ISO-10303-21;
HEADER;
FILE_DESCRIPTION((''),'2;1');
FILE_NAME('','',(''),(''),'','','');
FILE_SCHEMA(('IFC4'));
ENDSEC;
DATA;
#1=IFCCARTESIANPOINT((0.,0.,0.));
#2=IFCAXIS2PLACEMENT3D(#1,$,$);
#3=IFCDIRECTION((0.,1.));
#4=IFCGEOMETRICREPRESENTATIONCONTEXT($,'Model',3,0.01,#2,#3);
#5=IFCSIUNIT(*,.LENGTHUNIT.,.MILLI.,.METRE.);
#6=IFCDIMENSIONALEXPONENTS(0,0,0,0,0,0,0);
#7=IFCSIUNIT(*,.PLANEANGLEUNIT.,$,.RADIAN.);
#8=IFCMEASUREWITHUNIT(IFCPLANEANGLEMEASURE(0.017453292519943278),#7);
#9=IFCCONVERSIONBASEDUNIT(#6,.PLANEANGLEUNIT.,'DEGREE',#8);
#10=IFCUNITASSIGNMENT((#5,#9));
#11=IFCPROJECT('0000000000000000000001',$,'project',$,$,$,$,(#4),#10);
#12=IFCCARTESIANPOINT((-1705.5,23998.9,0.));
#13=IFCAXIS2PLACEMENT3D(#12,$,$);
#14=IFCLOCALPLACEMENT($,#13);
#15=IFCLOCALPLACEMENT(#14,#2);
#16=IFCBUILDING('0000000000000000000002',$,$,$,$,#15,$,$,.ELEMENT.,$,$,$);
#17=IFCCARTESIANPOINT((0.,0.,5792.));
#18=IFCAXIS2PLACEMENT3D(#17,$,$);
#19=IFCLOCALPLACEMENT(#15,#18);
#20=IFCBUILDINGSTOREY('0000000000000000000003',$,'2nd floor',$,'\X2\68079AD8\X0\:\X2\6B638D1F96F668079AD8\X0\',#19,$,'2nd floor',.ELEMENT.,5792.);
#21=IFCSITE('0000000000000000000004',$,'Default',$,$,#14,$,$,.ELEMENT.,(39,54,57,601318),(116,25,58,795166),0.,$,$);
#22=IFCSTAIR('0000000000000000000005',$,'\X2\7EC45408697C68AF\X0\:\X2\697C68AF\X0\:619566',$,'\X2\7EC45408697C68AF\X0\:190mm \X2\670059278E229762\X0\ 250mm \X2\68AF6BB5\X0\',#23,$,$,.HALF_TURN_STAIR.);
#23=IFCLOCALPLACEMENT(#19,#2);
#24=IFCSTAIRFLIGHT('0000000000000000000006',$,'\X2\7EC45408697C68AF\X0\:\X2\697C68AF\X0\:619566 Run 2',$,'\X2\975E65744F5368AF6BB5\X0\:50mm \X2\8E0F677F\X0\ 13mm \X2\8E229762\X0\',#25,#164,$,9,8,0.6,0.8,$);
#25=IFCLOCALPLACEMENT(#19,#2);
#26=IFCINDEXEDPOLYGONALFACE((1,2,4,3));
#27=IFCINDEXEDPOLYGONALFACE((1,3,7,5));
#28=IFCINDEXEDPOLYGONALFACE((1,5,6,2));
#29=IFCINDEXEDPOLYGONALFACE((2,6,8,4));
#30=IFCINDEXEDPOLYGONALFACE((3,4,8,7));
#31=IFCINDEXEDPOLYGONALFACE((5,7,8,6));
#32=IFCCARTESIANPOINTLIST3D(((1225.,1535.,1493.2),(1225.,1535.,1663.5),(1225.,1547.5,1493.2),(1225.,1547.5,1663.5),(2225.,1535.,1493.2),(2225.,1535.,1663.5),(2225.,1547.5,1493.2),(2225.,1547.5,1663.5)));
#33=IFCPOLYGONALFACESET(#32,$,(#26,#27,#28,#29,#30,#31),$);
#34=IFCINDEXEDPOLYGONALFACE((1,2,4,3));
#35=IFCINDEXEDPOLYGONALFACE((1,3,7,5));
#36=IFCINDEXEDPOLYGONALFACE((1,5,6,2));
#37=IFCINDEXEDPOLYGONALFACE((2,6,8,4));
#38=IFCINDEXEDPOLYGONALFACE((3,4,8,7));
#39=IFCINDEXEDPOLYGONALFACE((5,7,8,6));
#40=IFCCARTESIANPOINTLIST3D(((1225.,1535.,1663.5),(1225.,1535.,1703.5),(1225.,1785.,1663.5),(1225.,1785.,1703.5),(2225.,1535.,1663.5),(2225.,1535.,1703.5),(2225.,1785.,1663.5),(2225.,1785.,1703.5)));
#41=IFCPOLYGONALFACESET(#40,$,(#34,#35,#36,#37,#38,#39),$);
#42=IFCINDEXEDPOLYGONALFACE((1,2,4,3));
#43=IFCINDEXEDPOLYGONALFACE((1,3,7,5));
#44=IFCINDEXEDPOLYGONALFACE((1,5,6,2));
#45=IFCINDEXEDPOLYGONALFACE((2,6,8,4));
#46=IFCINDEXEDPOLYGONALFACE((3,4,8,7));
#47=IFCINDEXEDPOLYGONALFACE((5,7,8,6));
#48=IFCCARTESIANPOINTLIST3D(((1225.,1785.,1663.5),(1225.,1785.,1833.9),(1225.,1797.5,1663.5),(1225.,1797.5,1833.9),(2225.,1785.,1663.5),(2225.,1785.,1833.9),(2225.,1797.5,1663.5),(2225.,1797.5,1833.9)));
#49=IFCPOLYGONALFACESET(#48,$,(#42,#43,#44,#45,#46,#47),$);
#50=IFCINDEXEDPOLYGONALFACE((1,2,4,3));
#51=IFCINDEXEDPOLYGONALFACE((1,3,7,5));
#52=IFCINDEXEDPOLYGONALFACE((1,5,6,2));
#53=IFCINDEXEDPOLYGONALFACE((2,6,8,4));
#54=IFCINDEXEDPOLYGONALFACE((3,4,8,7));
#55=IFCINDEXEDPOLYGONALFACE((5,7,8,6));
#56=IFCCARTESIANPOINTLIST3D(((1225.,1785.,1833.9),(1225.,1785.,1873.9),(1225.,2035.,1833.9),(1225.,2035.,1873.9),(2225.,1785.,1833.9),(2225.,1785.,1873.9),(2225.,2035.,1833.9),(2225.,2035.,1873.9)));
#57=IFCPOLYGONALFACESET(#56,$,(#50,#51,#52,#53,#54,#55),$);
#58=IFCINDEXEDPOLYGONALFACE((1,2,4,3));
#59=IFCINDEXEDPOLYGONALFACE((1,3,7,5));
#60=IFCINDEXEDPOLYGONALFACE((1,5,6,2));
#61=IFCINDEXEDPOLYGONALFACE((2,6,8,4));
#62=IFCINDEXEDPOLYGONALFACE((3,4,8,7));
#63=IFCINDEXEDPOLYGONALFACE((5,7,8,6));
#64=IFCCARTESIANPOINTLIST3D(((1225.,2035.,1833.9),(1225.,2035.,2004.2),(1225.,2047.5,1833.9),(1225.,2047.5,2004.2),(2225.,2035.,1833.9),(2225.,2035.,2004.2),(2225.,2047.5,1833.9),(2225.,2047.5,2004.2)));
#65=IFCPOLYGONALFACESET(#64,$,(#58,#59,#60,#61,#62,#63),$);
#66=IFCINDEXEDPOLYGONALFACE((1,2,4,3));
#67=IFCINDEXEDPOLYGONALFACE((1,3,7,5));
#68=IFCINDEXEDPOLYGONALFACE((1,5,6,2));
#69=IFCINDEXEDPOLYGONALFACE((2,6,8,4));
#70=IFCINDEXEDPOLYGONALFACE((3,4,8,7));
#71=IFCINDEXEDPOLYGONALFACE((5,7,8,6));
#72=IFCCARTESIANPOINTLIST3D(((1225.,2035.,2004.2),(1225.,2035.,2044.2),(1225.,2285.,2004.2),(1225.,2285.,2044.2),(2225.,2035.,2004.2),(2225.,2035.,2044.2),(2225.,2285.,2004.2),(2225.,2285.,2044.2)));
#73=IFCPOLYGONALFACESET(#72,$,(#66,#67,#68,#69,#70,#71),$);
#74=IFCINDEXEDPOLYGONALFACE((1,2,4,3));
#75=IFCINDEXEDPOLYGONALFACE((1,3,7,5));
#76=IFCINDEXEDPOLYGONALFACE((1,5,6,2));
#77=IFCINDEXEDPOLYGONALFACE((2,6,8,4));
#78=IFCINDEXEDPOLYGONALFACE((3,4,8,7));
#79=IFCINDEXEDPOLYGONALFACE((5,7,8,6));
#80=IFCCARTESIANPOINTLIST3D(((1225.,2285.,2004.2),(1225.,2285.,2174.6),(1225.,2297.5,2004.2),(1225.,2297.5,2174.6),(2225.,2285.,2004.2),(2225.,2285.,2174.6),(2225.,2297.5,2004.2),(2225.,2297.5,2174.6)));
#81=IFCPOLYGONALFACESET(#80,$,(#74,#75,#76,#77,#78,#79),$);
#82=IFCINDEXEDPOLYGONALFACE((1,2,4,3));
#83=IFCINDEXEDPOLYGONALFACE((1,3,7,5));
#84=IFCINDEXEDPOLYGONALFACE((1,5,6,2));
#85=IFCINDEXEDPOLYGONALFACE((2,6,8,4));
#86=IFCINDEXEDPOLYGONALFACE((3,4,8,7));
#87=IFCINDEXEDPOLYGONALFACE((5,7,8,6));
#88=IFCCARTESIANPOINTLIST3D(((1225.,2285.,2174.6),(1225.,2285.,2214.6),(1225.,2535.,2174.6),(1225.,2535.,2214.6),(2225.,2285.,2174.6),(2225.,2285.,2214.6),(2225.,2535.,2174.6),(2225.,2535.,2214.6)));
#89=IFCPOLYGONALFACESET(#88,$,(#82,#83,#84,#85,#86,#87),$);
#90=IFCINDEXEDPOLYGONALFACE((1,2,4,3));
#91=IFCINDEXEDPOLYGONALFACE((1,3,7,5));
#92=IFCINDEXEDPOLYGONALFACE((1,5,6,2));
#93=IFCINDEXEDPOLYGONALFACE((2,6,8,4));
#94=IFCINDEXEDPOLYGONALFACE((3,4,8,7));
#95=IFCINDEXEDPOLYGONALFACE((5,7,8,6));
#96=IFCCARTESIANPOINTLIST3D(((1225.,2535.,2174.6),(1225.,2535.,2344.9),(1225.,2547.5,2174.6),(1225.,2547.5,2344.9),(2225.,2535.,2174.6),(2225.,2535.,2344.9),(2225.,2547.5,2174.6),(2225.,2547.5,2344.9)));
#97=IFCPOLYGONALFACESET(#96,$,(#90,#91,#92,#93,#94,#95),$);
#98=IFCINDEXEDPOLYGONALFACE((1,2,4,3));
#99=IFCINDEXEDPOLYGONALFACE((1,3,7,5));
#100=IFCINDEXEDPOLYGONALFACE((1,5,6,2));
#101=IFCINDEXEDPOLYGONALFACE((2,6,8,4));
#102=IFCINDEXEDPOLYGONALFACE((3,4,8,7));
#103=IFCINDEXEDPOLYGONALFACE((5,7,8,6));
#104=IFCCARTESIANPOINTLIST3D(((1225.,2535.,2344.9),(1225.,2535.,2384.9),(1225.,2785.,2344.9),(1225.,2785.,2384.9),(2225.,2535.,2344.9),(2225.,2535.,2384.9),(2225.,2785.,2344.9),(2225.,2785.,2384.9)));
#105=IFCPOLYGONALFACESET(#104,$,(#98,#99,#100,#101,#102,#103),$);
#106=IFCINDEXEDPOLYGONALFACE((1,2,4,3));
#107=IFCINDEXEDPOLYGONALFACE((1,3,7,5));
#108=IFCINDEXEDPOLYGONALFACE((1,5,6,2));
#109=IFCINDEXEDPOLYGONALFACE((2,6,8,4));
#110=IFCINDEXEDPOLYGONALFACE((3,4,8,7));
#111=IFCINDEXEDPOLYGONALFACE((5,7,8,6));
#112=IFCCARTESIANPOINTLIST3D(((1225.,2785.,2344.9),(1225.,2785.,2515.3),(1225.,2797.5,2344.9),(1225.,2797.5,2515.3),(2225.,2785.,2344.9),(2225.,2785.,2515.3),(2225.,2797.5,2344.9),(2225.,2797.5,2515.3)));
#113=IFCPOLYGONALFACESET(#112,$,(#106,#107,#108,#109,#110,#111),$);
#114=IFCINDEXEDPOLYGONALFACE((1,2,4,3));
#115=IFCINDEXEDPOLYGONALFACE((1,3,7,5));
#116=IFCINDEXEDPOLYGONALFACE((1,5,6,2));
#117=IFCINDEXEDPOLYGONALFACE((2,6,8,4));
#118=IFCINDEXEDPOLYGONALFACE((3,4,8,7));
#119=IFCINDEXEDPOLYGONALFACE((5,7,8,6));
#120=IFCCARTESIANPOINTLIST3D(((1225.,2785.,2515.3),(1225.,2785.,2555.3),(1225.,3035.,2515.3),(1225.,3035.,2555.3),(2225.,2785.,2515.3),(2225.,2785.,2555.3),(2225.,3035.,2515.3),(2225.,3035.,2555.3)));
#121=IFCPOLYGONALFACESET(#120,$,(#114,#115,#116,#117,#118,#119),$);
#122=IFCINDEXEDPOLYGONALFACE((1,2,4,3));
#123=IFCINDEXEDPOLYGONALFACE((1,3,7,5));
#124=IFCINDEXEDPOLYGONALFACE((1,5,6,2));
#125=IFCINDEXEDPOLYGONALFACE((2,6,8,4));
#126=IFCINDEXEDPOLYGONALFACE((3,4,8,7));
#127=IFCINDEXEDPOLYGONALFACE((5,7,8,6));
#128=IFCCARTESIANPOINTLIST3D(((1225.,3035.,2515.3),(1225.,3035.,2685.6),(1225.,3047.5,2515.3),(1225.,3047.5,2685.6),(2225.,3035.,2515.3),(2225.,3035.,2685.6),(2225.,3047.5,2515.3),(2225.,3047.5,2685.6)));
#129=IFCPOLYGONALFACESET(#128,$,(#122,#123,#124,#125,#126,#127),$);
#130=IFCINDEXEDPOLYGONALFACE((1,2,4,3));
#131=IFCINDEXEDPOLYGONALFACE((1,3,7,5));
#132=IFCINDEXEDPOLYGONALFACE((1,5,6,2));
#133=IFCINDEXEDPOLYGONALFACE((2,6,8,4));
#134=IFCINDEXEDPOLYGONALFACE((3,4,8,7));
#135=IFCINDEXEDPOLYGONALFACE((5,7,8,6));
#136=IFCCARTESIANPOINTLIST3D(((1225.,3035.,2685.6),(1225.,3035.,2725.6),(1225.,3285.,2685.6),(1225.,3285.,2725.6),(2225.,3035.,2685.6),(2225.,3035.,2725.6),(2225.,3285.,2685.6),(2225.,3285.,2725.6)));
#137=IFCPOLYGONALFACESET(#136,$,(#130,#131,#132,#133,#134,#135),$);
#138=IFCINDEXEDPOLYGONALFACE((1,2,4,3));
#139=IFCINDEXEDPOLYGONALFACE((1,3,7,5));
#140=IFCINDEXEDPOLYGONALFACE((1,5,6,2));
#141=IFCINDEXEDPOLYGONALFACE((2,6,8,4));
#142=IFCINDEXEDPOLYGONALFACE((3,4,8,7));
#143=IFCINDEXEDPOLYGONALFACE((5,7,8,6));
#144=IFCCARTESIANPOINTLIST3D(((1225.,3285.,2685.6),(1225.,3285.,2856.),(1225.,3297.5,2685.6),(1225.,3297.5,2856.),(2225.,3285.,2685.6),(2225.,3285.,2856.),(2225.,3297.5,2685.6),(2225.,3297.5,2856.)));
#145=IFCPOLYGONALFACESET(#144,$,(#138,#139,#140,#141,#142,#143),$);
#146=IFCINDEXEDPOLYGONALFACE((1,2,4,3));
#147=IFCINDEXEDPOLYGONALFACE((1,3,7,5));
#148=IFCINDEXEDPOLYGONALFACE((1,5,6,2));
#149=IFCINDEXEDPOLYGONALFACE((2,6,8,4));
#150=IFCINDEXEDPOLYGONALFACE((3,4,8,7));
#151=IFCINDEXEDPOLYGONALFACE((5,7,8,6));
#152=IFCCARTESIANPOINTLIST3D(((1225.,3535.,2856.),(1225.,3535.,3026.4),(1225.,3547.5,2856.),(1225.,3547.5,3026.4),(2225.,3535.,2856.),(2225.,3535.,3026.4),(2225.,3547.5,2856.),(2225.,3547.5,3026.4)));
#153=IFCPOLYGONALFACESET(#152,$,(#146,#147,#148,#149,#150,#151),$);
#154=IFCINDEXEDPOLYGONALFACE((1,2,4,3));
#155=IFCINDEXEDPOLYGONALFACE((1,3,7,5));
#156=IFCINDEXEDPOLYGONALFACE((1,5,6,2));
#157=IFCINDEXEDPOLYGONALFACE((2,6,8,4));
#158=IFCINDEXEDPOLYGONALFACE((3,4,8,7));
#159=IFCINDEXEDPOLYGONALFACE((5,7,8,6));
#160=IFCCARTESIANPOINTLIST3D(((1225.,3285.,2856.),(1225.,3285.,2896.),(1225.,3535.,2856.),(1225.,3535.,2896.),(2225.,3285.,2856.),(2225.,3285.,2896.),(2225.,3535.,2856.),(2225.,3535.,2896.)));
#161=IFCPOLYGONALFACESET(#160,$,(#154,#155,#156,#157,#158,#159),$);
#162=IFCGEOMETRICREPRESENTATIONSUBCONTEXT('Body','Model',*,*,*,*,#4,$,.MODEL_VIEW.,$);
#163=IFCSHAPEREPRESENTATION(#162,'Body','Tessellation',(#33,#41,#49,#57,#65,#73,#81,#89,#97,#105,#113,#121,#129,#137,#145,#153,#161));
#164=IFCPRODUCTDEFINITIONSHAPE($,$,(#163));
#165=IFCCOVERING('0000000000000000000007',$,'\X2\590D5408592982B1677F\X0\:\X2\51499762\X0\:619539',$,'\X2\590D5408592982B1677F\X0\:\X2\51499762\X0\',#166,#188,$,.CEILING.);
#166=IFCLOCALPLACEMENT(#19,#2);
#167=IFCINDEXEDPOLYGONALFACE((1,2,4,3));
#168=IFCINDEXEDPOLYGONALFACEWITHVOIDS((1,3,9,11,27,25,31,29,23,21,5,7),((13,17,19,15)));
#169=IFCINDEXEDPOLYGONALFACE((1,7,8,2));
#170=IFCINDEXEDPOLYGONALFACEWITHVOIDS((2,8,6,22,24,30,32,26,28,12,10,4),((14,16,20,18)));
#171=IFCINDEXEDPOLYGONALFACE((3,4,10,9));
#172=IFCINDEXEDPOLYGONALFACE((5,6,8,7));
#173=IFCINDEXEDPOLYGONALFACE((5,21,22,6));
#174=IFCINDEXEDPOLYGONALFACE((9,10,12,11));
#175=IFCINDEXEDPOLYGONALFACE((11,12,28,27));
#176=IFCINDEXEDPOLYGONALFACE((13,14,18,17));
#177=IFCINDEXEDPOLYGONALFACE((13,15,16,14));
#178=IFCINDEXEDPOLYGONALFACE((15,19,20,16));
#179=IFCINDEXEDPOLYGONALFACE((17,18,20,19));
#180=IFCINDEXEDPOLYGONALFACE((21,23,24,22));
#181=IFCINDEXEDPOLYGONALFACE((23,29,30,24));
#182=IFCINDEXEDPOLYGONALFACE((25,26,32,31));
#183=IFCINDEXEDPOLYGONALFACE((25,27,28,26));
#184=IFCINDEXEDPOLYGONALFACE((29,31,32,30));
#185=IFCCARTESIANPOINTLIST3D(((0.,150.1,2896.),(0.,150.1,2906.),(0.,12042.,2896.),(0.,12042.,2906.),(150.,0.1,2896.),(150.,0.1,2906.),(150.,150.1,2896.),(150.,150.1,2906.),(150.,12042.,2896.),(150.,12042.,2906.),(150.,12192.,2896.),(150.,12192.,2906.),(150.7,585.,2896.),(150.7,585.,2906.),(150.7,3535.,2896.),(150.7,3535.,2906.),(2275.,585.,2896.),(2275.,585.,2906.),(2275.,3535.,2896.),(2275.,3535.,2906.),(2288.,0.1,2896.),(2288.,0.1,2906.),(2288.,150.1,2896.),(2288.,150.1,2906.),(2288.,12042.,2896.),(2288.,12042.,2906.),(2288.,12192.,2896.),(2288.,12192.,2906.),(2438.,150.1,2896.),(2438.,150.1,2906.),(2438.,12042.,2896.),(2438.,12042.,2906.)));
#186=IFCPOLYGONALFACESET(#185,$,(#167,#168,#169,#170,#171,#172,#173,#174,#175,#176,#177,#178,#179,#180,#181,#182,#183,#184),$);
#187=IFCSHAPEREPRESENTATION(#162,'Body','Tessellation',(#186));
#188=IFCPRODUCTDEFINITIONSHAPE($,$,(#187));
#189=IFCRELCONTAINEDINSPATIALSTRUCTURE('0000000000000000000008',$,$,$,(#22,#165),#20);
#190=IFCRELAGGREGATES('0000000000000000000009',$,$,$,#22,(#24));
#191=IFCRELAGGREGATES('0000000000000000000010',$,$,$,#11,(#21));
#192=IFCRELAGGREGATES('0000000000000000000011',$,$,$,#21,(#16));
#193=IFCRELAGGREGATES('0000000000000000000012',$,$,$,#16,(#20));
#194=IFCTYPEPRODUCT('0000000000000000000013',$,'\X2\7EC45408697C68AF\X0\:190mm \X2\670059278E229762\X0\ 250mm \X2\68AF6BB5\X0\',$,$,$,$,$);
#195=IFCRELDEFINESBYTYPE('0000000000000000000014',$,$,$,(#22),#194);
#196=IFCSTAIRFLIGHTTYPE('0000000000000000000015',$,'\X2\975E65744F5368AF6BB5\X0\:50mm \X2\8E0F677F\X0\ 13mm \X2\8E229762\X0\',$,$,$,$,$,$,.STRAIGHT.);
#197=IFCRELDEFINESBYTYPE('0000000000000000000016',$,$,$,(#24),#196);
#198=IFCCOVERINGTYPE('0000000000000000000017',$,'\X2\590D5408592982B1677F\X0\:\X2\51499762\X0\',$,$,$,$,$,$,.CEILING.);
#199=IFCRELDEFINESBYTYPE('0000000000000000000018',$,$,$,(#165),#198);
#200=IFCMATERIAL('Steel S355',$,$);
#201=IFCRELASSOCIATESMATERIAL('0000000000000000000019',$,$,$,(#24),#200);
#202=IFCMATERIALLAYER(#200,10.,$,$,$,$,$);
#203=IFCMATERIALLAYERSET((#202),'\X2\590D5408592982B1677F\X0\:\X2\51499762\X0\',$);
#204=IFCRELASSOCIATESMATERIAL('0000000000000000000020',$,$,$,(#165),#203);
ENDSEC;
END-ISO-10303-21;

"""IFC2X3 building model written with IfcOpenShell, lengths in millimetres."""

from ifc_helpers import new_model, entity, si_unit, converted_unit, direction, frame, frame_2d, origin, origin_2d_with_axis, place, context, subcontext, project, spatial, polyline, rectangle, outline, extrude, material, layer, layer_set, layer_usage, type_object, element, aggregate, save


model = new_model("IFC2X3")

# Units and contexts
model_context = context("Model", 3, precision=0.01, world=origin(), true_north=direction((0.0, 1.0)))
body_context = subcontext(model_context, "Body", "Model", "MODEL_VIEW")
ifc_project = project(units=[si_unit("LENGTHUNIT", "METRE", prefix="MILLI"), converted_unit("PLANEANGLEUNIT", "DEGREE", entity("IfcPlaneAngleMeasure", 0.017453292519943278), si_unit("PLANEANGLEUNIT", "RADIAN"), dimensions=[0, 0, 0, 0, 0, 0, 0])], contexts=[model_context])

# Site, building, storey
site_placement = place(None, frame((-1705.5, 23998.9, 0.0)))
site = spatial("IfcSite", under=ifc_project, at=site_placement, Name="Default", CompositionType="ELEMENT", RefLatitude=(39, 54, 57, 601318), RefLongitude=(116, 25, 58, 795166), RefElevation=0.0)
building_placement = place(site_placement, origin())
building = spatial("IfcBuilding", under=site, at=building_placement, CompositionType="ELEMENT")
storey_placement = place(building_placement, frame((0.0, 0.0, 5792.0)))
storey = spatial("IfcBuildingStorey", under=building, at=storey_placement, Name="2nd floor", ObjectType="标高:正负零标高", LongName="2nd floor", CompositionType="ELEMENT", Elevation=5792.0)

# Stair
type_product = type_object("IfcTypeProduct", Name="组合楼梯:190mm 最大踢面 250mm 梯段")
stair_placement = place(storey_placement, origin())
stair = element("IfcStair", 1, at=stair_placement, inside=storey, type_object=type_product, Name="组合楼梯:楼梯:619566", ObjectType="组合楼梯:190mm 最大踢面 250mm 梯段", ShapeType="HALF_TURN_STAIR")
ifc_material_1 = material(Name="Steel S355")

# Stair flight
stair_flight_type = type_object("IfcStairFlightType", Name="非整体梯段:50mm 踏板 13mm 踢面", PredefinedType="STRAIGHT")
stair_flight_1_placement = place(stair_placement, origin())
stair_flight_1 = element("IfcStairFlight", 2, at=stair_flight_1_placement, type_object=stair_flight_type, material=ifc_material_1, Name="组合楼梯:楼梯:619566 Run 2", ObjectType="非整体梯段:50mm 踏板 13mm 踢面", NumberOfRiser=9, NumberOfTreads=8, RiserHeight=0.6, TreadLength=0.8, context=body_context, shape_type="SweptSolid", body=[
    extrude(rectangle(XDim=1000.0, YDim=12.5, at=origin_2d_with_axis()), frame((1725.0, 1541.2, 1493.2), z_axis=(0.0, 0.0, 1.0), x_axis=(-1.0, 0.0, 0.0)), (0.0, 0.0, 1.0), 170.4),
    extrude(rectangle(XDim=250.0, YDim=1000.0, at=origin_2d_with_axis()), frame((1725.0, 1660.0, 1663.5), z_axis=(0.0, 0.0, 1.0), x_axis=(0.0, -1.0, 0.0)), (0.0, 0.0, 1.0), 40.0),
    extrude(rectangle(XDim=1000.0, YDim=12.5, at=frame_2d((0.0, 0.0), x_axis=(1.0, 0.0))), frame((1725.0, 1791.2, 1663.5), z_axis=(0.0, 0.0, 1.0), x_axis=(-1.0, 0.0, 0.0)), (0.0, 0.0, 1.0), 170.4),
    extrude(rectangle(XDim=250.0, YDim=1000.0, at=origin_2d_with_axis()), frame((1725.0, 1910.0, 1833.9), z_axis=(0.0, 0.0, 1.0), x_axis=(0.0, -1.0, 0.0)), (0.0, 0.0, 1.0), 40.0),
    extrude(rectangle(XDim=1000.0, YDim=12.5, at=origin_2d_with_axis()), frame((1725.0, 2041.2, 1833.9), z_axis=(0.0, 0.0, 1.0), x_axis=(-1.0, 0.0, 0.0)), (0.0, 0.0, 1.0), 170.4),
    extrude(rectangle(XDim=250.0, YDim=1000.0, at=origin_2d_with_axis()), frame((1725.0, 2160.0, 2004.2), z_axis=(0.0, 0.0, 1.0), x_axis=(0.0, -1.0, 0.0)), (0.0, 0.0, 1.0), 40.0),
    extrude(rectangle(XDim=1000.0, YDim=12.5, at=origin_2d_with_axis()), frame((1725.0, 2291.2, 2004.2), z_axis=(0.0, 0.0, 1.0), x_axis=(-1.0, 0.0, 0.0)), (0.0, 0.0, 1.0), 170.4),
    extrude(rectangle(XDim=250.0, YDim=1000.0, at=frame_2d((0.0, 0.0), x_axis=(1.0, 0.0))), frame((1725.0, 2410.0, 2174.6), z_axis=(0.0, 0.0, 1.0), x_axis=(0.0, -1.0, 0.0)), (0.0, 0.0, 1.0), 40.0),
    extrude(rectangle(XDim=1000.0, YDim=12.5, at=origin_2d_with_axis()), frame((1725.0, 2541.2, 2174.6), z_axis=(0.0, 0.0, 1.0), x_axis=(-1.0, 0.0, 0.0)), (0.0, 0.0, 1.0), 170.4),
    extrude(rectangle(XDim=250.0, YDim=1000.0, at=frame_2d((0.0, 0.0), x_axis=(1.0, 0.0))), frame((1725.0, 2660.0, 2344.9), z_axis=(0.0, 0.0, 1.0), x_axis=(0.0, -1.0, 0.0)), (0.0, 0.0, 1.0), 40.0),
    extrude(rectangle(XDim=1000.0, YDim=12.5, at=origin_2d_with_axis()), frame((1725.0, 2791.2, 2344.9), z_axis=(0.0, 0.0, 1.0), x_axis=(-1.0, 0.0, 0.0)), (0.0, 0.0, 1.0), 170.4),
    extrude(rectangle(XDim=250.0, YDim=1000.0, at=frame_2d((0.0, 0.0), x_axis=(1.0, 0.0))), frame((1725.0, 2910.0, 2515.3), z_axis=(0.0, 0.0, 1.0), x_axis=(0.0, -1.0, 0.0)), (0.0, 0.0, 1.0), 40.0),
    extrude(rectangle(XDim=1000.0, YDim=12.5, at=origin_2d_with_axis()), frame((1725.0, 3041.2, 2515.3), z_axis=(0.0, 0.0, 1.0), x_axis=(-1.0, 0.0, 0.0)), (0.0, 0.0, 1.0), 170.4),
    extrude(rectangle(XDim=250.0, YDim=1000.0, at=frame_2d((0.0, 0.0), x_axis=(1.0, 0.0))), frame((1725.0, 3160.0, 2685.6), z_axis=(0.0, 0.0, 1.0), x_axis=(0.0, -1.0, 0.0)), (0.0, 0.0, 1.0), 40.0),
    extrude(rectangle(XDim=1000.0, YDim=12.5, at=frame_2d((0.0, 0.0), x_axis=(1.0, 0.0))), frame((1725.0, 3291.2, 2685.6), z_axis=(0.0, 0.0, 1.0), x_axis=(-1.0, 0.0, 0.0)), (0.0, 0.0, 1.0), 170.4),
    extrude(rectangle(XDim=1000.0, YDim=12.5, at=frame_2d((0.0, 0.0), x_axis=(1.0, 0.0))), frame((1725.0, 3541.2, 2856.0), z_axis=(0.0, 0.0, 1.0), x_axis=(-1.0, 0.0, 0.0)), (0.0, 0.0, 1.0), 170.4),
    extrude(rectangle(XDim=250.0, YDim=1000.0, at=frame_2d((0.0, 0.0), x_axis=(1.0, 0.0))), frame((1725.0, 3410.0, 2856.0), z_axis=(0.0, 0.0, 1.0), x_axis=(0.0, -1.0, 0.0)), (0.0, 0.0, 1.0), 40.0),
])
aggregate(stair, [stair_flight_1])

# Covering
ifc_layer_1 = layer(ifc_material_1, 10.0)
ifc_layer_set_1 = layer_set([ifc_layer_1], Name="复合天花板:光面")
ifc_layer_usage_1 = layer_usage(ifc_layer_set_1, "AXIS3", "NEGATIVE", 10.0)
covering_type = type_object("IfcCoveringType", Name="复合天花板:光面", PredefinedType="CEILING")
covering_placement = place(storey_placement, origin())
element("IfcCovering", 3, at=covering_placement, inside=storey, type_object=covering_type, material=ifc_layer_usage_1, Name="复合天花板:光面:619539", ObjectType="复合天花板:光面", PredefinedType="CEILING", context=body_context, shape_type="SweptSolid", body=[
    extrude(outline(polyline([(5946.0, -1069.0), (6096.0, -1069.0), (6096.0, 1069.0), (5945.9, 1069.0), (5945.9, 1219.0), (-5946.0, 1219.0), (-5946.0, 1069.0), (-6096.0, 1069.0), (-6096.0, -1069.0), (-5946.0, -1069.0), (-5946.0, -1219.0), (5946.0, -1219.0), (5946.0, -1069.0)]), holes=[polyline([(-2561.0, 1068.3), (-2561.0, -1056.0), (-5511.0, -1056.0), (-5511.0, 1068.3), (-2561.0, 1068.3)])]), frame((1219.0, 6096.0, 2896.0), z_axis=(0.0, 0.0, 1.0), x_axis=(0.0, 1.0, 0.0)), (0.0, 0.0, 1.0), 10.0),
])

save(model, "model.ifc")
